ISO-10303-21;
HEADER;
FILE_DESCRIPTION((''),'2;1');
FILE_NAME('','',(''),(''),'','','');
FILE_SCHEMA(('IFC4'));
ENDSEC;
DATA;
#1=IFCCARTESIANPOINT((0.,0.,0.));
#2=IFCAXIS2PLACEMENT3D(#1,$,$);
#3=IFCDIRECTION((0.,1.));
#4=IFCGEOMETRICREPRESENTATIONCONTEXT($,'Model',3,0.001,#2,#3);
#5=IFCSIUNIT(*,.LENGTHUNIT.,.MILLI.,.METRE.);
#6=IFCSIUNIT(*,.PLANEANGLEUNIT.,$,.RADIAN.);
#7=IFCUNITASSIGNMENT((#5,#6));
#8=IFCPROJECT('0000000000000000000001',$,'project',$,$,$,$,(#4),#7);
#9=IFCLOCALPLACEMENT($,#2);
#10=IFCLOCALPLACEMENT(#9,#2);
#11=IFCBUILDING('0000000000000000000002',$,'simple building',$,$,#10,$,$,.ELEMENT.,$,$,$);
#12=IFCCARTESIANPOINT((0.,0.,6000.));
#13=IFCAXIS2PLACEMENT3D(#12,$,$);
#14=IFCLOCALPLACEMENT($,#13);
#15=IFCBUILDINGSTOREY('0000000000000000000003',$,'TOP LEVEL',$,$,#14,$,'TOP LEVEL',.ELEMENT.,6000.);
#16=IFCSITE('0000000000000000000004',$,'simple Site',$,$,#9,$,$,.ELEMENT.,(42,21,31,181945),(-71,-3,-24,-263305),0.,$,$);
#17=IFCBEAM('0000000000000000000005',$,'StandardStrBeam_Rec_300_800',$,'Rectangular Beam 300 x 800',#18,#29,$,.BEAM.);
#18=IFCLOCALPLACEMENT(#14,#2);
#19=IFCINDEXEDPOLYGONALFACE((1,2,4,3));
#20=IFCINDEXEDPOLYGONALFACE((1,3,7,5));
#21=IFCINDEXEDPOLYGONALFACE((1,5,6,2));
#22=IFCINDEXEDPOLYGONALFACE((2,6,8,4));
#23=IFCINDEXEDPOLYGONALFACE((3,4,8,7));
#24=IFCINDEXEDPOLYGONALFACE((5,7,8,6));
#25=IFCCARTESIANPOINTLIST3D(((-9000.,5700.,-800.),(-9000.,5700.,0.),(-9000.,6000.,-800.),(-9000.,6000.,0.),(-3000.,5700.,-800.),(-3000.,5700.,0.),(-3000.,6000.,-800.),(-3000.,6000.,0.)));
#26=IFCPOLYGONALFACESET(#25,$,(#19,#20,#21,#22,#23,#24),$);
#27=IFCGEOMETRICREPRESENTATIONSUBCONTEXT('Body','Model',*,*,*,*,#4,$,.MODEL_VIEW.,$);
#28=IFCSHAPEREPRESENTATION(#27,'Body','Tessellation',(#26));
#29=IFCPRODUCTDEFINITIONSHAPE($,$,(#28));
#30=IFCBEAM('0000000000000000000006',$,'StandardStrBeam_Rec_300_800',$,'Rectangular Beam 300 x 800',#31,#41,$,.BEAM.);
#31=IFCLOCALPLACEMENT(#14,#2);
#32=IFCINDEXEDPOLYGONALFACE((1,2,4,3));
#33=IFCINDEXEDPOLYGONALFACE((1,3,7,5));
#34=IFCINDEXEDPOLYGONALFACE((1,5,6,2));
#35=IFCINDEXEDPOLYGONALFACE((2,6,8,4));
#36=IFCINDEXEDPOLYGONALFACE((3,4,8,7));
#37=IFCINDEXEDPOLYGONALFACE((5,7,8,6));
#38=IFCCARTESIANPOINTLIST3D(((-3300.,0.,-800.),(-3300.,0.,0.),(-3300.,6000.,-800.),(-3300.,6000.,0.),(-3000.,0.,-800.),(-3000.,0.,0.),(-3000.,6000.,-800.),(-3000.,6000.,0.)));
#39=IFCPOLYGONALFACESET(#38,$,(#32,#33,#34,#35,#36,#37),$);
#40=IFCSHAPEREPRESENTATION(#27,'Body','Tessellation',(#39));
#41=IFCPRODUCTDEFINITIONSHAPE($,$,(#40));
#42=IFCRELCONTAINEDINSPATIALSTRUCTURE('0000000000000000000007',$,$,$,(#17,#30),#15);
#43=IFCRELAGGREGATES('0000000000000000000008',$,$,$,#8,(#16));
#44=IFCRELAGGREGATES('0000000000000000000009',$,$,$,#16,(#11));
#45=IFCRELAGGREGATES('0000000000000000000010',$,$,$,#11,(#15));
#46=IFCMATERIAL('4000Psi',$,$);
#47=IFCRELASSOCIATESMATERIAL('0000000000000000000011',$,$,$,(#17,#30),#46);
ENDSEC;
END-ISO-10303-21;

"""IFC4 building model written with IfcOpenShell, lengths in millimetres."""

from ifc_helpers import new_model, si_unit, direction, frame, origin, origin_with_axes, origin_2d_with_axis, place, context, subcontext, project, spatial, rectangle, extrude, material, material_profile, profile_set, profile_usage, element, save


model = new_model("IFC4")

# Units and contexts
model_context = context("Model", 3, precision=0.001, world=origin(), true_north=direction((0.0, 1.0)))
body_context = subcontext(model_context, "Body", "Model", "MODEL_VIEW")
ifc_project = project(units=[si_unit("LENGTHUNIT", "METRE", prefix="MILLI"), si_unit("PLANEANGLEUNIT", "RADIAN")], contexts=[model_context])

# Site, building, storey
site_placement = place(None, origin())
site = spatial("IfcSite", under=ifc_project, at=site_placement, Name="simple Site", CompositionType="ELEMENT", RefLatitude=(42, 21, 31, 181945), RefLongitude=(-71, -3, -24, -263305), RefElevation=0.0)
building_placement = place(site_placement, origin())
building = spatial("IfcBuilding", under=site, at=building_placement, Name="simple building", CompositionType="ELEMENT")
storey_placement = place(None, frame((0.0, 0.0, 6000.0)))
storey = spatial("IfcBuildingStorey", under=building, at=storey_placement, Name="TOP LEVEL", LongName="TOP LEVEL", CompositionType="ELEMENT", Elevation=6000.0)

# Beams
ifc_material = material(Name="4000Psi")
ifc_material_profile = material_profile(ifc_material, rectangle(XDim=300.0, YDim=800.0, at=origin_2d_with_axis()))
ifc_profile_set = profile_set([ifc_material_profile])
ifc_profile_usage_1 = profile_usage(ifc_profile_set, cardinal=7)
beam_1_placement = place(None, frame((-9000.0, 5850.0, 5600.0), z_axis=(1.0, 0.0, 0.0), x_axis=(0.0, -1.0, 0.0)))
element("IfcBeam", 1, at=beam_1_placement, inside=storey, material=ifc_profile_usage_1, Name="StandardStrBeam_Rec_300_800", ObjectType="Rectangular Beam 300 x 800", PredefinedType="BEAM", context=body_context, shape_type="SweptSolid", body=[
    extrude(rectangle(XDim=300.0, YDim=800.0, at=origin_2d_with_axis()), origin_with_axes(), (0.0, 0.0, 1.0), 6000.0),
])
ifc_profile_usage_2 = profile_usage(ifc_profile_set, cardinal=9)
beam_2_placement = place(None, frame((-3150.0, 0.0, 5600.0), z_axis=(0.0, 1.0, 0.0), x_axis=(1.0, 0.0, 0.0)))
element("IfcBeam", 2, at=beam_2_placement, inside=storey, material=ifc_profile_usage_2, Name="StandardStrBeam_Rec_300_800", ObjectType="Rectangular Beam 300 x 800", PredefinedType="BEAM", context=body_context, shape_type="SweptSolid", body=[
    extrude(rectangle(XDim=300.0, YDim=800.0, at=origin_2d_with_axis()), origin_with_axes(), (0.0, 0.0, 1.0), 6000.0),
])

save(model, "model.ifc")
